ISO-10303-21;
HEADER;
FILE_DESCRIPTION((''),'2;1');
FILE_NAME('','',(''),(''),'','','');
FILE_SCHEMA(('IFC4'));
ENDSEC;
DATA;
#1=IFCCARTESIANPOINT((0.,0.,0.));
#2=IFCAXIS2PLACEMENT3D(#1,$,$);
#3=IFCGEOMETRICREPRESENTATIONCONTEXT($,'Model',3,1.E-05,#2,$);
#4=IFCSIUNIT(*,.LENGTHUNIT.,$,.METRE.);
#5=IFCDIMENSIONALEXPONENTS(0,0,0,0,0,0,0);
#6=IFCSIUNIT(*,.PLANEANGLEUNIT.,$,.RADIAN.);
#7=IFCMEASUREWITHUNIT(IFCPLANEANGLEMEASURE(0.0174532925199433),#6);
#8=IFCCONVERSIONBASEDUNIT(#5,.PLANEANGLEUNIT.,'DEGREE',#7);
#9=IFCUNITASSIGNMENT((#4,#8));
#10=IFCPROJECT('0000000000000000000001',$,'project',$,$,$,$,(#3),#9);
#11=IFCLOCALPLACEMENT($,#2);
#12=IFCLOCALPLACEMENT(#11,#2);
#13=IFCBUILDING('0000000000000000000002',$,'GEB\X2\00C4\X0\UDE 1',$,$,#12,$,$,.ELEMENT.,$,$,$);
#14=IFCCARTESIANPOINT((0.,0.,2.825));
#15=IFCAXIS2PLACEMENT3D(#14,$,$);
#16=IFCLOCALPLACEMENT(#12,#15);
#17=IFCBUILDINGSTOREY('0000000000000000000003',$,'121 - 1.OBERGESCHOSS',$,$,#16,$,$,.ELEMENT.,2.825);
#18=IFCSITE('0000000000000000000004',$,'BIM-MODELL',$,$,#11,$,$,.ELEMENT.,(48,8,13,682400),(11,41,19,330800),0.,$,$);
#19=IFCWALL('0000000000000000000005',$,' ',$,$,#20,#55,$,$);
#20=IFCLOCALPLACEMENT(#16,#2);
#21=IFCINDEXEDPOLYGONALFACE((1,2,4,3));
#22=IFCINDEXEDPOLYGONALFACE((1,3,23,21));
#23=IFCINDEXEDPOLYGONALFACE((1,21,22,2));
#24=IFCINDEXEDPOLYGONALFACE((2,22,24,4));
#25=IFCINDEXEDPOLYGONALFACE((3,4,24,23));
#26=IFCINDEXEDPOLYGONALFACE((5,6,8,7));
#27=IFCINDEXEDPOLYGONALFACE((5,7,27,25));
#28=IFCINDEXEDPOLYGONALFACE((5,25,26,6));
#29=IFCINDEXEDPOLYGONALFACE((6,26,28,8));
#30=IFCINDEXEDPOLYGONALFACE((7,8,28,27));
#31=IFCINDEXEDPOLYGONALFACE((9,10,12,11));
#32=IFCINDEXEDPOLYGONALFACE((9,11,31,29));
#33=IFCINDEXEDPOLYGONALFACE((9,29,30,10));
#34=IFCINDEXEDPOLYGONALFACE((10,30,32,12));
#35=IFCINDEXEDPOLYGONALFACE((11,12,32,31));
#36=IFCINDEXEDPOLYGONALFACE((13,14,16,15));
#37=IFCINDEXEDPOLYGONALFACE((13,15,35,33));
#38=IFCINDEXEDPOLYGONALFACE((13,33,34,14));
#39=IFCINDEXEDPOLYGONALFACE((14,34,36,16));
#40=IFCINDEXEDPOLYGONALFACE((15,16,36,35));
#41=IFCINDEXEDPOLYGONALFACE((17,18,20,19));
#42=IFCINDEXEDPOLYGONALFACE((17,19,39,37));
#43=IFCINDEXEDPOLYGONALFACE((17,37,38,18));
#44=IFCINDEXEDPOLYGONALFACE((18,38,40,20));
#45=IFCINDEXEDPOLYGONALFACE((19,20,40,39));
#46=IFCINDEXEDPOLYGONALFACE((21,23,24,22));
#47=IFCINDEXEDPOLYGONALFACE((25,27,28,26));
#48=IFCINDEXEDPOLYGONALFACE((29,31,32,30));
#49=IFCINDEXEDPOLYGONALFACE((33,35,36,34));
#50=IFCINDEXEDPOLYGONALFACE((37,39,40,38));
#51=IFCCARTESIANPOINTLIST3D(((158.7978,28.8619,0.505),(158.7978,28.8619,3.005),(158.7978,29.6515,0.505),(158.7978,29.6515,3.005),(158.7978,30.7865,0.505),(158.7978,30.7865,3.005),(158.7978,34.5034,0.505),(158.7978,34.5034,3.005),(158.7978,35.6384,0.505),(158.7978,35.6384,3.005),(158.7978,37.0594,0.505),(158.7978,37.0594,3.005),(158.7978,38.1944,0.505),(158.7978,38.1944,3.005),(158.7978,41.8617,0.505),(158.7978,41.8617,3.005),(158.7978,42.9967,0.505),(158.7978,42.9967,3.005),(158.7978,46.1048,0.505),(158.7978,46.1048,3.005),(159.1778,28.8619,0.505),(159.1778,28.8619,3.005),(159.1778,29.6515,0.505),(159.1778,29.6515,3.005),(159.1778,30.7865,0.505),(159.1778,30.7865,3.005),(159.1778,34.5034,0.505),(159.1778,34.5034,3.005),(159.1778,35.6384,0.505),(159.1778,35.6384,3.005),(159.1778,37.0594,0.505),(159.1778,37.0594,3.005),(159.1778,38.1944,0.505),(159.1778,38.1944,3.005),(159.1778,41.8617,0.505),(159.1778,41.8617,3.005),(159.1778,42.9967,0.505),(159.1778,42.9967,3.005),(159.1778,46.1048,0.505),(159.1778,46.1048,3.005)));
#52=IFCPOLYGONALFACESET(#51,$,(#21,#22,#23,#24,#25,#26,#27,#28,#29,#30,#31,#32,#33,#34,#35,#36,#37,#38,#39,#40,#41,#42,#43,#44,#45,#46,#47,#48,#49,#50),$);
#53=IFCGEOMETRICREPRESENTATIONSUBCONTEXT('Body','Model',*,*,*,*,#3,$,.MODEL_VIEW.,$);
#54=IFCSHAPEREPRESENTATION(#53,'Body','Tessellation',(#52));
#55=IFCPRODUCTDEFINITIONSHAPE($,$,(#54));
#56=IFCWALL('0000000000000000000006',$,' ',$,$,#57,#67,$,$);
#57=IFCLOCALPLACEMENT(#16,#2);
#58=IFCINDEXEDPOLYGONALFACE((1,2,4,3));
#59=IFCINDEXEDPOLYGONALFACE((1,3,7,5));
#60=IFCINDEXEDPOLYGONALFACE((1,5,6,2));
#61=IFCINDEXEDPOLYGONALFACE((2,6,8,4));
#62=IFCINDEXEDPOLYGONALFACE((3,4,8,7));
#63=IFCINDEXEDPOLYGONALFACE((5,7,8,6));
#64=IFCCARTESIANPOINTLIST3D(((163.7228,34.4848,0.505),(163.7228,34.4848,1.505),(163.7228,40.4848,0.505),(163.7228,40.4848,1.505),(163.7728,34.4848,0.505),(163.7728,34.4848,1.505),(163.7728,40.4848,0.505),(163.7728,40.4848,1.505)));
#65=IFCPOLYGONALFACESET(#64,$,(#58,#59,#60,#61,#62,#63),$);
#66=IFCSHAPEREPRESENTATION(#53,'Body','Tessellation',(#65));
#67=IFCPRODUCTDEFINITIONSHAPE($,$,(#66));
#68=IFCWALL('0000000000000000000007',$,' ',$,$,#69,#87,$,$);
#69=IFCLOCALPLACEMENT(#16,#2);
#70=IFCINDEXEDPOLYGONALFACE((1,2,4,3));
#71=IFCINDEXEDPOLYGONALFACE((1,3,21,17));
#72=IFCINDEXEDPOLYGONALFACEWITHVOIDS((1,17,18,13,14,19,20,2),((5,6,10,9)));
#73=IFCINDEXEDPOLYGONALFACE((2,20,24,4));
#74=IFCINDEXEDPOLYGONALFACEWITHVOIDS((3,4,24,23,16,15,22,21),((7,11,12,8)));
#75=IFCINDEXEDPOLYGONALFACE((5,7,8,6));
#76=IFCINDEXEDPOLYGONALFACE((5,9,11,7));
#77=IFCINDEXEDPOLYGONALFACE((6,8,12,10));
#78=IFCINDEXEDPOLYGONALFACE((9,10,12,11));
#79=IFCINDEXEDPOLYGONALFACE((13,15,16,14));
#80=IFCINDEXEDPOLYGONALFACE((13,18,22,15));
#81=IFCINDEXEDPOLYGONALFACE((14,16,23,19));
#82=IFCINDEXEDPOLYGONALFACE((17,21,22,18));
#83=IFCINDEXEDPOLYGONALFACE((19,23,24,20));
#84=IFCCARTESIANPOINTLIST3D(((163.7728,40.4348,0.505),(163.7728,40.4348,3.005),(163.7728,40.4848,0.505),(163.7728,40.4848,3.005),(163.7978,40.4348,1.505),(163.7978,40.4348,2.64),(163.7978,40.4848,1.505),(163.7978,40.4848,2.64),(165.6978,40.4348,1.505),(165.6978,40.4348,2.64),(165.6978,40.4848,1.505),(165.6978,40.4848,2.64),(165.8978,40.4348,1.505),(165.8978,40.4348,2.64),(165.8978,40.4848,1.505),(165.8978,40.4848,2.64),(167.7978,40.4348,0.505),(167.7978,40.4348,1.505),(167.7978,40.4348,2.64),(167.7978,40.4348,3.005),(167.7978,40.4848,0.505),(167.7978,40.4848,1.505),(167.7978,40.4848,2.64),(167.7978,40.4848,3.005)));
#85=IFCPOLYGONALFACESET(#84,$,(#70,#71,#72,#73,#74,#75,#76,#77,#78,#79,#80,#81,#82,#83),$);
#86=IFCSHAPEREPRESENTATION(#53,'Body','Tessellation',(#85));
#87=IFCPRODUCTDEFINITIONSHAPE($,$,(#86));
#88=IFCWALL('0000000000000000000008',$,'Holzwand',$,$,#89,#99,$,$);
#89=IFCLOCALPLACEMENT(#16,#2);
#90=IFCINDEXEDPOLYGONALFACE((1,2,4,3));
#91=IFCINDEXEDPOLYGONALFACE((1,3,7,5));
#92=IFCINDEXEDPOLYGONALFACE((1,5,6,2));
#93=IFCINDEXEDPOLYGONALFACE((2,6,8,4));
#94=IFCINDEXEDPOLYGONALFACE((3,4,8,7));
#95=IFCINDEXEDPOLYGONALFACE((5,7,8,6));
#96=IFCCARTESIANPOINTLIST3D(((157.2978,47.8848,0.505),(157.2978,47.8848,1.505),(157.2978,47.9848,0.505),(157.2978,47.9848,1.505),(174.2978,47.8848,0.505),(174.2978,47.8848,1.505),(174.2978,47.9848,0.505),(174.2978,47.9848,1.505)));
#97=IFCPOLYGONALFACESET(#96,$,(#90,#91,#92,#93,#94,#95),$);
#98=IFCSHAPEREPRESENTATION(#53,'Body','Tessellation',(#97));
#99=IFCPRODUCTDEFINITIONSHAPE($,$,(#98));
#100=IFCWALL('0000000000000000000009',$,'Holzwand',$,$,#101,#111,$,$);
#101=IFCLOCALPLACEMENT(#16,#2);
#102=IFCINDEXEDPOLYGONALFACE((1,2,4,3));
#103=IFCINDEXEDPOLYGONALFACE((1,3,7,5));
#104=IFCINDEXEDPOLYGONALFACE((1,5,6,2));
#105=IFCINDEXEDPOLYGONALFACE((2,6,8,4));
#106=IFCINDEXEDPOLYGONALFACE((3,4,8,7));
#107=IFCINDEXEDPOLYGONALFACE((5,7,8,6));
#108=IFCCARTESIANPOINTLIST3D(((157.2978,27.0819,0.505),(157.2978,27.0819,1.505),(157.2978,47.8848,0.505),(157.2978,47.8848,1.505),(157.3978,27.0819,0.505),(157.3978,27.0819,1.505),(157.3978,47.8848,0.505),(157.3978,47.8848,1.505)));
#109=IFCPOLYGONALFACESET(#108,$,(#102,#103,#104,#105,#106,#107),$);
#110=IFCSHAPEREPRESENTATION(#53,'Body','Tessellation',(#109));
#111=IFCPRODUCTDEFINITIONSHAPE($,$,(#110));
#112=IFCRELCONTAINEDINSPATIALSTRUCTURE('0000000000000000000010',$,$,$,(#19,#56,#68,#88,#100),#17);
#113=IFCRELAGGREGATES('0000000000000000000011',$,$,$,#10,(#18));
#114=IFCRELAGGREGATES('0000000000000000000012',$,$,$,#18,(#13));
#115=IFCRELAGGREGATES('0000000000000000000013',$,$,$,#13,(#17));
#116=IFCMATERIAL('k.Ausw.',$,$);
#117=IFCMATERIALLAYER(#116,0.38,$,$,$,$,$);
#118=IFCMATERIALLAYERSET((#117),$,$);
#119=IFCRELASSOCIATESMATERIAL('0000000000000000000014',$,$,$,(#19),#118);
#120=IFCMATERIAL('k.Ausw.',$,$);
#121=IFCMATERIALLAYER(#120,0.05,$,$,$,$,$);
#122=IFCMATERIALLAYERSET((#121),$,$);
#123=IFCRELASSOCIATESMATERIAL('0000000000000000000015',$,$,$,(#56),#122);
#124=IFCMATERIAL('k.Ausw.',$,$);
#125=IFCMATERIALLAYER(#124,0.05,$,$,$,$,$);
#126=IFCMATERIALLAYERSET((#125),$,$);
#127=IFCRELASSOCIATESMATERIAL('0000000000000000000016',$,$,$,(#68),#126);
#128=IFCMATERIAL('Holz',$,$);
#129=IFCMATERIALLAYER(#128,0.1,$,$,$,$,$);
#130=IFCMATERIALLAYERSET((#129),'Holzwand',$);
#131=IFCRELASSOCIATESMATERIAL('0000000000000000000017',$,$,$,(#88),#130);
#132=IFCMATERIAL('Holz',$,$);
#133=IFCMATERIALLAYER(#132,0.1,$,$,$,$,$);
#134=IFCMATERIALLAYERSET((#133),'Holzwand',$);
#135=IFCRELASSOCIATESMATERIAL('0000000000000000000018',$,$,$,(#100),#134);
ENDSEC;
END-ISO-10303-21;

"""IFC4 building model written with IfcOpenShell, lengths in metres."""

from ifc_helpers import new_model, entity, si_unit, converted_unit, frame, frame_2d, origin, origin_with_axes, place, context, subcontext, project, spatial, polyline, rectangle, outline, extrude, material, layer, layer_set, layer_usage, element, save


model = new_model("IFC4")

# Units and contexts
model_context = context("Model", 3, precision=1e-05, world=origin())
body_context = subcontext(model_context, "Body", "Model", "MODEL_VIEW")
ifc_project = project(units=[si_unit("LENGTHUNIT", "METRE"), converted_unit("PLANEANGLEUNIT", "DEGREE", entity("IfcPlaneAngleMeasure", 0.0174532925199433), si_unit("PLANEANGLEUNIT", "RADIAN"), dimensions=[0, 0, 0, 0, 0, 0, 0])], contexts=[model_context])

# Site, building, storey
site_placement = place(None, origin())
site = spatial("IfcSite", under=ifc_project, at=site_placement, Name="BIM-MODELL", CompositionType="ELEMENT", RefLatitude=(48, 8, 13, 682400), RefLongitude=(11, 41, 19, 330800), RefElevation=0.0)
building_placement = place(site_placement, origin())
building = spatial("IfcBuilding", under=site, at=building_placement, Name="GEBÄUDE 1", CompositionType="ELEMENT")
storey_placement = place(building_placement, frame((0.0, 0.0, 2.825)))
storey = spatial("IfcBuildingStorey", under=building, at=storey_placement, Name="121 - 1.OBERGESCHOSS", CompositionType="ELEMENT", Elevation=2.825)

# Wall, openings
ifc_material_1 = material(Name="k.Ausw.")
ifc_layer_1 = layer(ifc_material_1, 0.38)
ifc_layer_set_1 = layer_set([ifc_layer_1])
ifc_layer_usage_1 = layer_usage(ifc_layer_set_1, "AXIS2", "POSITIVE", 0.0)
wall_1_placement = place(storey_placement, frame((158.7978, 46.1048, 0.505), z_axis=(0.0, 0.0, 1.0), x_axis=(0.0, -1.0, 0.0)))
wall_1 = element("IfcWall", 1, at=wall_1_placement, inside=storey, material=ifc_layer_usage_1, Name=" ", context=body_context, shape_type="SweptSolid", body=[
    extrude(rectangle(XDim=17.2429, YDim=0.38, at=frame_2d((8.6214, 0.19), x_axis=(1.0, 0.0))), origin_with_axes(), (0.0, 0.0, 1.0), 2.5),
])
opening_1_placement = place(wall_1_placement, frame((16.4533, 0.38, 0.0), z_axis=(0.0, -1.0, 0.0), x_axis=(0.0, 0.0, 1.0)))
element("IfcOpeningElement", 2, at=opening_1_placement, cuts=wall_1, ObjectType="Opening", context=body_context, shape_type="SweptSolid", body=[
    extrude(outline(polyline([(0.0, 1.135), (2.5, 1.135), (2.5, 0.0), (0.0, 0.0), (0.0, 1.135)])), origin_with_axes(), (0.0, 0.0, 1.0), 0.38),
])
opening_2_placement = place(wall_1_placement, frame((9.0454, 0.38, 0.0), z_axis=(0.0, -1.0, 0.0), x_axis=(0.0, 0.0, 1.0)))
element("IfcOpeningElement", 3, at=opening_2_placement, cuts=wall_1, ObjectType="Opening", context=body_context, shape_type="SweptSolid", body=[
    extrude(outline(polyline([(0.0, 1.135), (2.5, 1.135), (2.5, 0.0), (0.0, 0.0), (0.0, 1.135)])), origin_with_axes(), (0.0, 0.0, 1.0), 0.38),
])
opening_3_placement = place(wall_1_placement, frame((4.2431, 0.38, 0.0), z_axis=(0.0, -1.0, 0.0), x_axis=(0.0, 0.0, 1.0)))
element("IfcOpeningElement", 4, at=opening_3_placement, cuts=wall_1, ObjectType="Opening", context=body_context, shape_type="SweptSolid", body=[
    extrude(outline(polyline([(0.0, 1.135), (2.5, 1.135), (2.5, 0.0), (0.0, 0.0), (0.0, 1.135)])), origin_with_axes(), (0.0, 0.0, 1.0), 0.38),
])
opening_4_placement = place(wall_1_placement, frame((11.6014, 0.38, 0.0), z_axis=(0.0, -1.0, 0.0), x_axis=(0.0, 0.0, 1.0)))
element("IfcOpeningElement", 5, at=opening_4_placement, cuts=wall_1, ObjectType="Opening", context=body_context, shape_type="SweptSolid", body=[
    extrude(outline(polyline([(0.0, 1.135), (2.5, 1.135), (2.5, 0.0), (0.0, 0.0), (0.0, 1.135)])), origin_with_axes(), (0.0, 0.0, 1.0), 0.38),
])

# Wall
ifc_material_2 = material(Name="k.Ausw.")
ifc_layer_2 = layer(ifc_material_2, 0.05)
ifc_layer_set_2 = layer_set([ifc_layer_2])
ifc_layer_usage_2 = layer_usage(ifc_layer_set_2, "AXIS2", "POSITIVE", 0.0)
wall_2_placement = place(storey_placement, frame((163.7228, 40.4848, 0.505), z_axis=(0.0, 0.0, 1.0), x_axis=(0.0, -1.0, 0.0)))
element("IfcWall", 6, at=wall_2_placement, inside=storey, material=ifc_layer_usage_2, Name=" ", context=body_context, shape_type="SweptSolid", body=[
    extrude(rectangle(XDim=6.0, YDim=0.05, at=frame_2d((3.0, 0.025), x_axis=(1.0, 0.0))), origin_with_axes(), (0.0, 0.0, 1.0), 1.0),
])

# Wall, openings
ifc_material_3 = material(Name="k.Ausw.")
ifc_layer_3 = layer(ifc_material_3, 0.05)
ifc_layer_set_3 = layer_set([ifc_layer_3])
ifc_layer_usage_3 = layer_usage(ifc_layer_set_3, "AXIS2", "POSITIVE", 0.0)
wall_3_placement = place(storey_placement, frame((167.7978, 40.4848, 0.505), z_axis=(0.0, 0.0, 1.0), x_axis=(-1.0, 0.0, 0.0)))
wall_3 = element("IfcWall", 7, at=wall_3_placement, inside=storey, material=ifc_layer_usage_3, Name=" ", context=body_context, shape_type="SweptSolid", body=[
    extrude(rectangle(XDim=4.025, YDim=0.05, at=frame_2d((2.0125, 0.025), x_axis=(1.0, 0.0))), origin_with_axes(), (0.0, 0.0, 1.0), 2.5),
])
opening_5_placement = place(wall_3_placement, frame((2.1, 0.0, 1.0), z_axis=(0.0, 1.0, 0.0), x_axis=(0.0, 0.0, 1.0)))
element("IfcOpeningElement", 8, at=opening_5_placement, cuts=wall_3, ObjectType="Opening", context=body_context, shape_type="SweptSolid", body=[
    extrude(outline(polyline([(0.0, 1.9), (1.135, 1.9), (1.135, 0.0), (0.0, 0.0), (0.0, 1.9)])), origin_with_axes(), (0.0, 0.0, 1.0), 0.05),
])
opening_6_placement = place(wall_3_placement, frame((0.0, 0.0, 1.0), z_axis=(0.0, 1.0, 0.0), x_axis=(0.0, 0.0, 1.0)))
element("IfcOpeningElement", 9, at=opening_6_placement, cuts=wall_3, ObjectType="Opening", context=body_context, shape_type="SweptSolid", body=[
    extrude(outline(polyline([(0.0, 1.9), (1.135, 1.9), (1.135, 0.0), (0.0, 0.0), (0.0, 1.9)])), origin_with_axes(), (0.0, 0.0, 1.0), 0.05),
])

# Walls
ifc_material_4 = material(Name="Holz")
ifc_layer_4 = layer(ifc_material_4, 0.1)
ifc_layer_set_4 = layer_set([ifc_layer_4], Name="Holzwand")
ifc_layer_usage_4 = layer_usage(ifc_layer_set_4, "AXIS2", "POSITIVE", 0.0)
wall_4_placement = place(storey_placement, frame((174.2978, 47.9848, 0.505), z_axis=(0.0, 0.0, 1.0), x_axis=(-1.0, 0.0, 0.0)))
element("IfcWall", 10, at=wall_4_placement, inside=storey, material=ifc_layer_usage_4, Name="Holzwand", context=body_context, shape_type="SweptSolid", body=[
    extrude(rectangle(XDim=17.0, YDim=0.1, at=frame_2d((8.5, 0.05), x_axis=(1.0, 0.0))), origin_with_axes(), (0.0, 0.0, 1.0), 1.0),
])
ifc_material_5 = material(Name="Holz")
ifc_layer_5 = layer(ifc_material_5, 0.1)
ifc_layer_set_5 = layer_set([ifc_layer_5], Name="Holzwand")
ifc_layer_usage_5 = layer_usage(ifc_layer_set_5, "AXIS2", "POSITIVE", 0.0)
wall_5_placement = place(storey_placement, frame((157.2978, 47.8848, 0.505), z_axis=(0.0, 0.0, 1.0), x_axis=(0.0, -1.0, 0.0)))
element("IfcWall", 11, at=wall_5_placement, inside=storey, material=ifc_layer_usage_5, Name="Holzwand", context=body_context, shape_type="SweptSolid", body=[
    extrude(rectangle(XDim=20.8029, YDim=0.1, at=frame_2d((10.4014, 0.05), x_axis=(1.0, 0.0))), origin_with_axes(), (0.0, 0.0, 1.0), 1.0),
])

save(model, "model.ifc")
